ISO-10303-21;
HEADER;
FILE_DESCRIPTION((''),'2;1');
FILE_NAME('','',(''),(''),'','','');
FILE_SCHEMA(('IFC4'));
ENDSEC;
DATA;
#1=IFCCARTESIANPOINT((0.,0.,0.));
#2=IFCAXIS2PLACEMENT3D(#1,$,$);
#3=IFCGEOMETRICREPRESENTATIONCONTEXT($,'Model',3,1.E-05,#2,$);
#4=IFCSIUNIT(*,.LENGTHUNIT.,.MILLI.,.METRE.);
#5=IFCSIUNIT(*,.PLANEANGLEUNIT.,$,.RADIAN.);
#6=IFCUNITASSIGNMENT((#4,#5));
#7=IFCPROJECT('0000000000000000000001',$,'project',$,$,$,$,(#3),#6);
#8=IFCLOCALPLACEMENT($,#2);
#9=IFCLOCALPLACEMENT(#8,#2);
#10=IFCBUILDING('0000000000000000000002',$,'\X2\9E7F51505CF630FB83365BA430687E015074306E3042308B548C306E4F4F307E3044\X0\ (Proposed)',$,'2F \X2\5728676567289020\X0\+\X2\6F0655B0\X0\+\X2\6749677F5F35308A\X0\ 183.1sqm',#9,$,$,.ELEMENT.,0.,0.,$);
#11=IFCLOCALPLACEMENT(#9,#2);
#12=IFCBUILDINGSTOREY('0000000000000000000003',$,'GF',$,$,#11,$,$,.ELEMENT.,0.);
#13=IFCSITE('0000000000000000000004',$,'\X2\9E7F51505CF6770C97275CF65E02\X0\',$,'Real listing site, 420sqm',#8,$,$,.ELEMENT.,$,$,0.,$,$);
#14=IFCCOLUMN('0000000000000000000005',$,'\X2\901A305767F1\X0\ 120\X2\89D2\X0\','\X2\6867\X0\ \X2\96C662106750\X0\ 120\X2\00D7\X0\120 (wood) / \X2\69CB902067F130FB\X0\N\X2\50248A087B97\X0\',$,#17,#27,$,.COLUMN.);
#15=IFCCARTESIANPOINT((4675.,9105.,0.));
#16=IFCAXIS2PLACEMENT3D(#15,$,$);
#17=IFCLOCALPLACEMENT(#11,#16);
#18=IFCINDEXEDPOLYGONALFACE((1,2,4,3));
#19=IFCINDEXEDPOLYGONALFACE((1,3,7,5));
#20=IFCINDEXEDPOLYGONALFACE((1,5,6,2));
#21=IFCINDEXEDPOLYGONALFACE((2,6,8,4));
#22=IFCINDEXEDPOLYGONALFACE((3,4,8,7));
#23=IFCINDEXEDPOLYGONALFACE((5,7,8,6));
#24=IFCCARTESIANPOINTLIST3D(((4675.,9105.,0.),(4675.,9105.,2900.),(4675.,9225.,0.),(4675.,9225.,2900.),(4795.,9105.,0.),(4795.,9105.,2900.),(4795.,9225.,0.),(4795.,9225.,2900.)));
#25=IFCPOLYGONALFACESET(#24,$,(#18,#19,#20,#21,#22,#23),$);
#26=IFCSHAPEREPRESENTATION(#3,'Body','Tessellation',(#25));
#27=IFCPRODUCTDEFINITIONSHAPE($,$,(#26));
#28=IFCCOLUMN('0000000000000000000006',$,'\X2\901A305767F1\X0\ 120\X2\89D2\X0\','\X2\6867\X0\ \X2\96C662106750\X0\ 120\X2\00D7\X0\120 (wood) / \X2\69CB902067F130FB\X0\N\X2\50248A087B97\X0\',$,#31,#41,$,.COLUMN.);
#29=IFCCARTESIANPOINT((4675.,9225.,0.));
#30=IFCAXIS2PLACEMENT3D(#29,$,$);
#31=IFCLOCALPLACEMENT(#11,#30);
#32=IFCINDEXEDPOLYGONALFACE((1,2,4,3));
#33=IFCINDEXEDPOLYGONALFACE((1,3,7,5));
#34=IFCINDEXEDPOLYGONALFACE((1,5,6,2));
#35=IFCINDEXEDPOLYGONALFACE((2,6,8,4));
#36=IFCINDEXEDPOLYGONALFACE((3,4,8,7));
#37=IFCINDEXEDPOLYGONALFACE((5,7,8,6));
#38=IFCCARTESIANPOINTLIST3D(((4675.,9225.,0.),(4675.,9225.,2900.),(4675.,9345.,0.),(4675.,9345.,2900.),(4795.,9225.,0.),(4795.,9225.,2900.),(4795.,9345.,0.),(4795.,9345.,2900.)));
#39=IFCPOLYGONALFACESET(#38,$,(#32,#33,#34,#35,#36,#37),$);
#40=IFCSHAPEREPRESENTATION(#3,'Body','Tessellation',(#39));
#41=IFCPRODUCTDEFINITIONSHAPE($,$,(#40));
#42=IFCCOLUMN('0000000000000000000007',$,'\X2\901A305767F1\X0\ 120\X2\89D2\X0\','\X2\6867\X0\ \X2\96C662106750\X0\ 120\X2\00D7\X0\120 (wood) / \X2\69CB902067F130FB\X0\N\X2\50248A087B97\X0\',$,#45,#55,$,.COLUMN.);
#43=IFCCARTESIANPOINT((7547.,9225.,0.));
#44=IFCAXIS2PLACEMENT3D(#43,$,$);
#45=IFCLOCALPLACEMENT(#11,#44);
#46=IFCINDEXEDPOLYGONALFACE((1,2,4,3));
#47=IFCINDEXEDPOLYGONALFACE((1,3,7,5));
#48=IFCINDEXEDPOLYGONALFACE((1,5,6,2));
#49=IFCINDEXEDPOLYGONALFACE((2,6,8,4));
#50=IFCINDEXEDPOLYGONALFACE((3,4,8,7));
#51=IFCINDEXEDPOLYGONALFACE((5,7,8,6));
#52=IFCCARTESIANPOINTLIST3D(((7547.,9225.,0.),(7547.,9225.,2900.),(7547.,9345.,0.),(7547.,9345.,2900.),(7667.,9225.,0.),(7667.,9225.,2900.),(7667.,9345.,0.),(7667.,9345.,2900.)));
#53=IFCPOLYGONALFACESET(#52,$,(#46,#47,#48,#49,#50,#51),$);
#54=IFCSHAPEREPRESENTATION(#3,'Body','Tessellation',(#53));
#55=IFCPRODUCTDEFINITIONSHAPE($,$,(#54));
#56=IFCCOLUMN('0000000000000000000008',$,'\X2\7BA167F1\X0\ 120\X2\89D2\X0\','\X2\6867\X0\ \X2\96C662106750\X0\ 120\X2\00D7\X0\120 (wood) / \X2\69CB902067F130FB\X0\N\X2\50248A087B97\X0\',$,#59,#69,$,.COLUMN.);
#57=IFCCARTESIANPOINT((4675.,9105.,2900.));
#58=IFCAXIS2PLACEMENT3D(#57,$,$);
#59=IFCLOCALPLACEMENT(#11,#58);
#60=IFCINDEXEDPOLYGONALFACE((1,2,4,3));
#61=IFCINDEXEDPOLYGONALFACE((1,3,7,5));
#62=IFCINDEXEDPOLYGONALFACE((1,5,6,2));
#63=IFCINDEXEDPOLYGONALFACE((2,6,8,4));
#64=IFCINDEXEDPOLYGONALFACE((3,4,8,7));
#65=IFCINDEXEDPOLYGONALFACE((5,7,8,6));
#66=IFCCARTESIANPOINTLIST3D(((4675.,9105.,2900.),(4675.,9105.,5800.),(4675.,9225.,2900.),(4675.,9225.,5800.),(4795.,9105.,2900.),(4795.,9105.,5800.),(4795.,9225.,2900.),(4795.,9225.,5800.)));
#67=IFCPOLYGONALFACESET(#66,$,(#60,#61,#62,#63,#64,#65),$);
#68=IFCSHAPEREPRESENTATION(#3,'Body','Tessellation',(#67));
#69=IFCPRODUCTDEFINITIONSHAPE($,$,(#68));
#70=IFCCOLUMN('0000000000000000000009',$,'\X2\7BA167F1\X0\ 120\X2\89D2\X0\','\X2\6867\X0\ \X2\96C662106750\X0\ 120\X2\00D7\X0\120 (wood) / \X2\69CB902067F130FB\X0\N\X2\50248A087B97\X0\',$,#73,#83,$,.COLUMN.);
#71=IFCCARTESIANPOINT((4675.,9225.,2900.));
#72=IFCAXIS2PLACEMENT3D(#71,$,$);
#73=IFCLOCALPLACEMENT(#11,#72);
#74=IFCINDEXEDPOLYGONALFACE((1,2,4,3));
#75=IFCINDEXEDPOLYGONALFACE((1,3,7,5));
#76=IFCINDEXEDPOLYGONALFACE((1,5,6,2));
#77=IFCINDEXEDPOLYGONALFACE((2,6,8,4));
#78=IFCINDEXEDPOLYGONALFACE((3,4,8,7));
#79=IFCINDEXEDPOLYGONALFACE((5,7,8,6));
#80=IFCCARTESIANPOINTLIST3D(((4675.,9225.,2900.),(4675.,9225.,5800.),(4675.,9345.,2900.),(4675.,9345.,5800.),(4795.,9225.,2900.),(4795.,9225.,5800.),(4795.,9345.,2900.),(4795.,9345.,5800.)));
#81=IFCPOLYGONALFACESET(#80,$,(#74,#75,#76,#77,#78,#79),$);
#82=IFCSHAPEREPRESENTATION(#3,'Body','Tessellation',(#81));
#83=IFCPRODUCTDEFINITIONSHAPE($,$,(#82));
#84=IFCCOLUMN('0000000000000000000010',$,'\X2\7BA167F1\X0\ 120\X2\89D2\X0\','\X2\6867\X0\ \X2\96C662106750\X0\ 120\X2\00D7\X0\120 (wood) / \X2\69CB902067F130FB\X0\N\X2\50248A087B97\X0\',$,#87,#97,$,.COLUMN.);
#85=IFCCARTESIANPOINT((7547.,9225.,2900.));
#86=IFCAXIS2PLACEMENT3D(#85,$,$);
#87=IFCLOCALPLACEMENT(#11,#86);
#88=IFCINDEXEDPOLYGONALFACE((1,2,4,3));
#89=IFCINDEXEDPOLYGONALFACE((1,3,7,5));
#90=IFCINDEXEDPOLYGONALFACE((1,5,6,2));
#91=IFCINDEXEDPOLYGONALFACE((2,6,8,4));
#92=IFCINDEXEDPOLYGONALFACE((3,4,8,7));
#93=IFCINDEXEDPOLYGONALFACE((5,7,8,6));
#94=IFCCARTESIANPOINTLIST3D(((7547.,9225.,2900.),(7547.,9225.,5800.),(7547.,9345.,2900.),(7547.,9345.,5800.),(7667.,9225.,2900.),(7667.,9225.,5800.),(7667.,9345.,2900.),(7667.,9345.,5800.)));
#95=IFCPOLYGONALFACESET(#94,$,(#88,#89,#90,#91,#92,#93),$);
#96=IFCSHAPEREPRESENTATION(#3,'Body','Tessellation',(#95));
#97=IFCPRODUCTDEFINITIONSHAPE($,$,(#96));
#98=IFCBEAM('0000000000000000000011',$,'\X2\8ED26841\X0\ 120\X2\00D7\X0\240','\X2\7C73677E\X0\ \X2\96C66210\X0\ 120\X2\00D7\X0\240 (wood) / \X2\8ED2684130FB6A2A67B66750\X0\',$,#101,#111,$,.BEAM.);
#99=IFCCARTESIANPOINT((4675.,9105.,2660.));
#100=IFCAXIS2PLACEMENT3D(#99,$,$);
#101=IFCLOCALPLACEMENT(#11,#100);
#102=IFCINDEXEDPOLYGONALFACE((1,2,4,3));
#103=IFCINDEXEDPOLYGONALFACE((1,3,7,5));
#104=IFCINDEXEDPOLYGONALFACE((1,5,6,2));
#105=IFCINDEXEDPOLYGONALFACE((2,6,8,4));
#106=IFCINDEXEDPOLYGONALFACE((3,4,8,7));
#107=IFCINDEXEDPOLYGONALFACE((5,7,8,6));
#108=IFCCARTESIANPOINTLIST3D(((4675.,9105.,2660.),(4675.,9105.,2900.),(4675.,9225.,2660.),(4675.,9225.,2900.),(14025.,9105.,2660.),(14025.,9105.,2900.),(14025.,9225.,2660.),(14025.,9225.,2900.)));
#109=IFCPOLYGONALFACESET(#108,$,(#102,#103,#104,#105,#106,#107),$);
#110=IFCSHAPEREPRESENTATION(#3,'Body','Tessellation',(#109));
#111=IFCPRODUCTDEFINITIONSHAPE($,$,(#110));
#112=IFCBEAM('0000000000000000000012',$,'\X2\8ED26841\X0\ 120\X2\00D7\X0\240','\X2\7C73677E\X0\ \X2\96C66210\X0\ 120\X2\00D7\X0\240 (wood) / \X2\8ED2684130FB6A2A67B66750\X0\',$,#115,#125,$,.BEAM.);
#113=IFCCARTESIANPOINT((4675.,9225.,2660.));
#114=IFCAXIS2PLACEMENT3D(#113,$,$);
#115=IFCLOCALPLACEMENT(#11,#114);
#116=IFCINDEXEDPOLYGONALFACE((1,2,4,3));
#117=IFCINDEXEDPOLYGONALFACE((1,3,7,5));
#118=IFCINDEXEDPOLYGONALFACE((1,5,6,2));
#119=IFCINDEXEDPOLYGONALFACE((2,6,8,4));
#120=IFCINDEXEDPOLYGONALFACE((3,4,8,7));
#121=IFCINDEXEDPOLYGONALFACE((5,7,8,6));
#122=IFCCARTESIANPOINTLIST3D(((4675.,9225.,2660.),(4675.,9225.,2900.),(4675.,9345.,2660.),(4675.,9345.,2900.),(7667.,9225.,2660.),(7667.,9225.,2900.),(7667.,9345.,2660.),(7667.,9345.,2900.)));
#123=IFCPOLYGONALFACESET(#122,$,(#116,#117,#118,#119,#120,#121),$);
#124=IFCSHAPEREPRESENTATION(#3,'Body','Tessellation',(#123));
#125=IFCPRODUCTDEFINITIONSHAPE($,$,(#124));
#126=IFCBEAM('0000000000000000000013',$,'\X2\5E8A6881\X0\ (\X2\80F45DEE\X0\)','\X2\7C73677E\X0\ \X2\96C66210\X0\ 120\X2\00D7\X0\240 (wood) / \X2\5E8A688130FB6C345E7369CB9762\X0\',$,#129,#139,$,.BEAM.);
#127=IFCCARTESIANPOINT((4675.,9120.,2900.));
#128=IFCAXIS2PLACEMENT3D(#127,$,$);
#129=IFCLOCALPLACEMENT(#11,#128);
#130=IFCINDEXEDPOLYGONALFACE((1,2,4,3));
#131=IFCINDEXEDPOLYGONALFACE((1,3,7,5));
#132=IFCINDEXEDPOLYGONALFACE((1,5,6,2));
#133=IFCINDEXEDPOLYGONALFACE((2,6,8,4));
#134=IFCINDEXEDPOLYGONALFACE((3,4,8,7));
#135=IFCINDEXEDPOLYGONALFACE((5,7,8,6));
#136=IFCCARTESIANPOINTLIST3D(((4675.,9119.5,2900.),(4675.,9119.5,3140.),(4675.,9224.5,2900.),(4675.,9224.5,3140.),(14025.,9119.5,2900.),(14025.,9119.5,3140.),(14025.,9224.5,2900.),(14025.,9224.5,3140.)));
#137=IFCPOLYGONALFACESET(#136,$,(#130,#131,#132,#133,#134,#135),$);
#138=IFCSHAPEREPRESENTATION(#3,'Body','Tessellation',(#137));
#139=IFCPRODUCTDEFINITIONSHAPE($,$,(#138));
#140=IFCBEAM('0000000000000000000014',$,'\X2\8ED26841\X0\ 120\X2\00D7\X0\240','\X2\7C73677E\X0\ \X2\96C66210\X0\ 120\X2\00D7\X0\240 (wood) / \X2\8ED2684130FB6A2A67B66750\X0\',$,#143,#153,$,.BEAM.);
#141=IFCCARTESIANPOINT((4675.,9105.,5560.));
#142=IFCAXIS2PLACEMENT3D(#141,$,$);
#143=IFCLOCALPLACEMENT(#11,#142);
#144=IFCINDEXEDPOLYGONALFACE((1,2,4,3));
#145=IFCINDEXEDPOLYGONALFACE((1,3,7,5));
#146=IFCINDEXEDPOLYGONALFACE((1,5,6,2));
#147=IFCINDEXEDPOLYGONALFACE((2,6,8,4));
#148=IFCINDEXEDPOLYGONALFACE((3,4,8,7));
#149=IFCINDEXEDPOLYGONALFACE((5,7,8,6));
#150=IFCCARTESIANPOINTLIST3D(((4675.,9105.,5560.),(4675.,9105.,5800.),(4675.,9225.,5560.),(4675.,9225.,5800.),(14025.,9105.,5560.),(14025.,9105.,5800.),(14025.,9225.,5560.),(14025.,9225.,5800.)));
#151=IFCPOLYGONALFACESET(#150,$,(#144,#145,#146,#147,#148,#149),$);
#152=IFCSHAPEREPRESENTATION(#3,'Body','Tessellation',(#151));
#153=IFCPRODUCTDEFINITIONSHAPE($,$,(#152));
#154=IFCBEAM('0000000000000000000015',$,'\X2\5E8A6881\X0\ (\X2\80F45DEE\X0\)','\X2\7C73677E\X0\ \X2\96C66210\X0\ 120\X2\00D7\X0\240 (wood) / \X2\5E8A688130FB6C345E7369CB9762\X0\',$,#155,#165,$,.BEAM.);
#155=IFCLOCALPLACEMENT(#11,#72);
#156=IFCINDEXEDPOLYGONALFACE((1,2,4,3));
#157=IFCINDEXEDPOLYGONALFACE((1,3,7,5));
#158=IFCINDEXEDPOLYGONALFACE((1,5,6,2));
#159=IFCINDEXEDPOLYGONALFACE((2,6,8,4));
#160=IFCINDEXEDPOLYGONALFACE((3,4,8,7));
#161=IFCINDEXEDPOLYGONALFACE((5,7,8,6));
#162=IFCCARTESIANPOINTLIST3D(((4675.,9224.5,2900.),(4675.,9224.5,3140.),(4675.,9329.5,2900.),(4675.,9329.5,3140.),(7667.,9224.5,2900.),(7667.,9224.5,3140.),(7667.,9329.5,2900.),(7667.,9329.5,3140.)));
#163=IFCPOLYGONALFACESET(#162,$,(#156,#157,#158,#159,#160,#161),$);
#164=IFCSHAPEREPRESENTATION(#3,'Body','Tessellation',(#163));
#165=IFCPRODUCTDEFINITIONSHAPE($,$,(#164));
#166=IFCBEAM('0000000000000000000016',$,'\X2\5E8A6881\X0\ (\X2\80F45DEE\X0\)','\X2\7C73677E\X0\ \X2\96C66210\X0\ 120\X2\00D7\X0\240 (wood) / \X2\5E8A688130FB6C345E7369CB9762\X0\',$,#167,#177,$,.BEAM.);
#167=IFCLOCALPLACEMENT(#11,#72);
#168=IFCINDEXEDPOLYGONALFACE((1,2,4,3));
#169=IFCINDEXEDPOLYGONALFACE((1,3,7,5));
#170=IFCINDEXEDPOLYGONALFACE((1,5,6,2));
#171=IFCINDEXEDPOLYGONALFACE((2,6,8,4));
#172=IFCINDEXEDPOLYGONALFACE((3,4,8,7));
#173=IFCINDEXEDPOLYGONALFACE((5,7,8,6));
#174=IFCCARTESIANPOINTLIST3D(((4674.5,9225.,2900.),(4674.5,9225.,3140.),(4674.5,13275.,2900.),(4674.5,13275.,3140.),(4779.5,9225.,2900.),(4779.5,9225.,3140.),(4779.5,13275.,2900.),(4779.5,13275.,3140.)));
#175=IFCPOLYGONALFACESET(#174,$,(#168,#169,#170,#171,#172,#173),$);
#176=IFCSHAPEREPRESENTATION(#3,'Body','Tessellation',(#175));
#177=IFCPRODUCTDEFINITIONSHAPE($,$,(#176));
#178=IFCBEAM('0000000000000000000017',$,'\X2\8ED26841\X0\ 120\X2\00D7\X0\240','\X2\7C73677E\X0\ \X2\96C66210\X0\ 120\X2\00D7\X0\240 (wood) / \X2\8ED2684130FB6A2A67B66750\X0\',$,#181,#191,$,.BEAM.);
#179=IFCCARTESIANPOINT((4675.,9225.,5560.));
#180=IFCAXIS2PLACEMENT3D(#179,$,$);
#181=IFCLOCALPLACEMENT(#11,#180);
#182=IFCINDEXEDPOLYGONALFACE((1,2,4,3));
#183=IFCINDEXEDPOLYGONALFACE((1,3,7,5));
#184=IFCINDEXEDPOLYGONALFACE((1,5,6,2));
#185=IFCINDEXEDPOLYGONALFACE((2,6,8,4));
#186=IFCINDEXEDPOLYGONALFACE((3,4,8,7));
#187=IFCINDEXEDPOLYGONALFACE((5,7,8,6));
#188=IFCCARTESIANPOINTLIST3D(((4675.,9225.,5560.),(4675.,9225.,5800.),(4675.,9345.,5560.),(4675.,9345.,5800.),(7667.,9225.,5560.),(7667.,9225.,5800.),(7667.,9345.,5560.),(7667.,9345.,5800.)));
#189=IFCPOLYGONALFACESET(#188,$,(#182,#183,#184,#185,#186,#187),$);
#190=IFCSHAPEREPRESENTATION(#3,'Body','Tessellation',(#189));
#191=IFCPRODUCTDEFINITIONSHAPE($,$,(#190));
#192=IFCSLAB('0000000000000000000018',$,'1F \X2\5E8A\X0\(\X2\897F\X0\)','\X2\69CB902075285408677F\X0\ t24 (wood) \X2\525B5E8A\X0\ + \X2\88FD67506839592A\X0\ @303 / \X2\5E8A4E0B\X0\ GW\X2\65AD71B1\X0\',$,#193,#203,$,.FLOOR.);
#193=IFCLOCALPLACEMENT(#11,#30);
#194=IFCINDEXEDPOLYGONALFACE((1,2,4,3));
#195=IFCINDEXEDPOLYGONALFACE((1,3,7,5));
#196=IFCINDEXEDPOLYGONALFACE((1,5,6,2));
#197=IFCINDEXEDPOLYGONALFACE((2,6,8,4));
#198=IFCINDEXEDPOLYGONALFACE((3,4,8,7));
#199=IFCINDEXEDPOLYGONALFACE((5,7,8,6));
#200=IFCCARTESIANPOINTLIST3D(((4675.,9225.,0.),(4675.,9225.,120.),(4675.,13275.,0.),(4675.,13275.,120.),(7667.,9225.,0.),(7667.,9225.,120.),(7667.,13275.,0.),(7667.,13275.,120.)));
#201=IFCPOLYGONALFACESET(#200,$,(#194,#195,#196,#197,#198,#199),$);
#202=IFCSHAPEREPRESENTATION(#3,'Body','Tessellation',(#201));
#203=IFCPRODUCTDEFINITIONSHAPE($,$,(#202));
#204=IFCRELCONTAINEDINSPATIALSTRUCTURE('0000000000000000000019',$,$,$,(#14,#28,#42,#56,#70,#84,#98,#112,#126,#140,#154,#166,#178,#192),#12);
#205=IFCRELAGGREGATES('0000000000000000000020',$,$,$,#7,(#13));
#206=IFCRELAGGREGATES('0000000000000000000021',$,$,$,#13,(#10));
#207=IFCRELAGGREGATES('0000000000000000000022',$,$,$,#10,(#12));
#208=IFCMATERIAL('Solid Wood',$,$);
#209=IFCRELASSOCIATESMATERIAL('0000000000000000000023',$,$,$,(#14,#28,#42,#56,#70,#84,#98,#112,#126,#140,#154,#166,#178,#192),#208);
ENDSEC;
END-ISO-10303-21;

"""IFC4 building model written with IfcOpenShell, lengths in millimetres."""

from ifc_helpers import new_model, si_unit, frame, frame_2d, origin, place, context, project, spatial, rectangle, extrude, material, element, save


model = new_model("IFC4")

# Units and contexts
model_context = context("Model", 3, precision=1e-05, world=origin())
ifc_project = project(units=[si_unit("LENGTHUNIT", "METRE", prefix="MILLI"), si_unit("PLANEANGLEUNIT", "RADIAN")], contexts=[model_context])

# Site, building, storey
site_placement = place(None, origin())
site = spatial("IfcSite", under=ifc_project, at=site_placement, Name="鹿児島県霧島市", ObjectType="Real listing site, 420sqm", CompositionType="ELEMENT", RefElevation=0.0)
building_placement = place(site_placement, origin())
building = spatial("IfcBuilding", under=site, at=building_placement, Name="鹿児島・茶室と縁側のある和の住まい (Proposed)", ObjectType="2F 在来木造+漆喰+杉板張り 183.1sqm", CompositionType="ELEMENT", ElevationOfRefHeight=0.0, ElevationOfTerrain=0.0)
storey_placement = place(building_placement, origin())
storey = spatial("IfcBuildingStorey", under=building, at=storey_placement, Name="GF", CompositionType="ELEMENT", Elevation=0.0)

# Columns
ifc_material_1 = material(Name="Solid Wood")
column_1_placement = place(storey_placement, frame((4675.0, 9105.0, 0.0)))
element("IfcColumn", 1, at=column_1_placement, inside=storey, material=ifc_material_1, Name="通し柱 120角", Description="桧 集成材 120×120 (wood) / 構造柱・N値計算", PredefinedType="COLUMN", context=model_context, shape_type="SweptSolid", body=[
    extrude(rectangle(XDim=120.0, YDim=120.0, at=frame_2d((60.0, 60.0))), frame((4675.0, 9105.0, 0.0)), (0.0, 0.0, 1.0), 2900.0),
])
column_2_placement = place(storey_placement, frame((4675.0, 9225.0, 0.0)))
element("IfcColumn", 2, at=column_2_placement, inside=storey, material=ifc_material_1, Name="通し柱 120角", Description="桧 集成材 120×120 (wood) / 構造柱・N値計算", PredefinedType="COLUMN", context=model_context, shape_type="SweptSolid", body=[
    extrude(rectangle(XDim=120.0, YDim=120.0, at=frame_2d((60.0, 60.0))), frame((4675.0, 9225.0, 0.0)), (0.0, 0.0, 1.0), 2900.0),
])
column_3_placement = place(storey_placement, frame((7547.0, 9225.0, 0.0)))
element("IfcColumn", 3, at=column_3_placement, inside=storey, material=ifc_material_1, Name="通し柱 120角", Description="桧 集成材 120×120 (wood) / 構造柱・N値計算", PredefinedType="COLUMN", context=model_context, shape_type="SweptSolid", body=[
    extrude(rectangle(XDim=120.0, YDim=120.0, at=frame_2d((60.0, 60.0))), frame((7547.0, 9225.0, 0.0)), (0.0, 0.0, 1.0), 2900.0),
])
column_4_placement = place(storey_placement, frame((4675.0, 9105.0, 2900.0)))
element("IfcColumn", 4, at=column_4_placement, inside=storey, material=ifc_material_1, Name="管柱 120角", Description="桧 集成材 120×120 (wood) / 構造柱・N値計算", PredefinedType="COLUMN", context=model_context, shape_type="SweptSolid", body=[
    extrude(rectangle(XDim=120.0, YDim=120.0, at=frame_2d((60.0, 60.0))), frame((4675.0, 9105.0, 2900.0)), (0.0, 0.0, 1.0), 2900.0),
])
column_5_placement = place(storey_placement, frame((4675.0, 9225.0, 2900.0)))
element("IfcColumn", 5, at=column_5_placement, inside=storey, material=ifc_material_1, Name="管柱 120角", Description="桧 集成材 120×120 (wood) / 構造柱・N値計算", PredefinedType="COLUMN", context=model_context, shape_type="SweptSolid", body=[
    extrude(rectangle(XDim=120.0, YDim=120.0, at=frame_2d((60.0, 60.0))), frame((4675.0, 9225.0, 2900.0)), (0.0, 0.0, 1.0), 2900.0),
])
column_6_placement = place(storey_placement, frame((7547.0, 9225.0, 2900.0)))
element("IfcColumn", 6, at=column_6_placement, inside=storey, material=ifc_material_1, Name="管柱 120角", Description="桧 集成材 120×120 (wood) / 構造柱・N値計算", PredefinedType="COLUMN", context=model_context, shape_type="SweptSolid", body=[
    extrude(rectangle(XDim=120.0, YDim=120.0, at=frame_2d((60.0, 60.0))), frame((7547.0, 9225.0, 2900.0)), (0.0, 0.0, 1.0), 2900.0),
])

# Beams
beam_1_placement = place(storey_placement, frame((4675.0, 9105.0, 2660.0)))
element("IfcBeam", 7, at=beam_1_placement, inside=storey, material=ifc_material_1, Name="軒桁 120×240", Description="米松 集成 120×240 (wood) / 軒桁・横架材", PredefinedType="BEAM", context=model_context, shape_type="SweptSolid", body=[
    extrude(rectangle(XDim=9350.0, YDim=120.0, at=frame_2d((4675.0, 60.0))), frame((4675.0, 9105.0, 2660.0)), (0.0, 0.0, 1.0), 240.0),
])
beam_2_placement = place(storey_placement, frame((4675.0, 9225.0, 2660.0)))
element("IfcBeam", 8, at=beam_2_placement, inside=storey, material=ifc_material_1, Name="軒桁 120×240", Description="米松 集成 120×240 (wood) / 軒桁・横架材", PredefinedType="BEAM", context=model_context, shape_type="SweptSolid", body=[
    extrude(rectangle(XDim=2992.0, YDim=120.0, at=frame_2d((1496.0, 60.0))), frame((4675.0, 9225.0, 2660.0)), (0.0, 0.0, 1.0), 240.0),
])
beam_3_placement = place(storey_placement, frame((4675.0, 9120.0, 2900.0)))
element("IfcBeam", 9, at=beam_3_placement, inside=storey, material=ifc_material_1, Name="床梁 (胴差)", Description="米松 集成 120×240 (wood) / 床梁・水平構面", PredefinedType="BEAM", context=model_context, shape_type="SweptSolid", body=[
    extrude(rectangle(XDim=9350.0, YDim=105.0, at=frame_2d((4675.0, 52.0))), frame((4675.0, 9120.0, 2900.0)), (0.0, 0.0, 1.0), 240.0),
])
beam_4_placement = place(storey_placement, frame((4675.0, 9105.0, 5560.0)))
element("IfcBeam", 10, at=beam_4_placement, inside=storey, material=ifc_material_1, Name="軒桁 120×240", Description="米松 集成 120×240 (wood) / 軒桁・横架材", PredefinedType="BEAM", context=model_context, shape_type="SweptSolid", body=[
    extrude(rectangle(XDim=9350.0, YDim=120.0, at=frame_2d((4675.0, 60.0))), frame((4675.0, 9105.0, 5560.0)), (0.0, 0.0, 1.0), 240.0),
])
beam_5_placement = place(storey_placement, frame((4675.0, 9225.0, 2900.0)))
element("IfcBeam", 11, at=beam_5_placement, inside=storey, material=ifc_material_1, Name="床梁 (胴差)", Description="米松 集成 120×240 (wood) / 床梁・水平構面", PredefinedType="BEAM", context=model_context, shape_type="SweptSolid", body=[
    extrude(rectangle(XDim=2992.0, YDim=105.0, at=frame_2d((1496.0, 52.0))), frame((4675.0, 9225.0, 2900.0)), (0.0, 0.0, 1.0), 240.0),
])
beam_6_placement = place(storey_placement, frame((4675.0, 9225.0, 2900.0)))
element("IfcBeam", 12, at=beam_6_placement, inside=storey, material=ifc_material_1, Name="床梁 (胴差)", Description="米松 集成 120×240 (wood) / 床梁・水平構面", PredefinedType="BEAM", context=model_context, shape_type="SweptSolid", body=[
    extrude(rectangle(XDim=105.0, YDim=4050.0, at=frame_2d((52.0, 2025.0))), frame((4675.0, 9225.0, 2900.0)), (0.0, 0.0, 1.0), 240.0),
])
beam_7_placement = place(storey_placement, frame((4675.0, 9225.0, 5560.0)))
element("IfcBeam", 13, at=beam_7_placement, inside=storey, material=ifc_material_1, Name="軒桁 120×240", Description="米松 集成 120×240 (wood) / 軒桁・横架材", PredefinedType="BEAM", context=model_context, shape_type="SweptSolid", body=[
    extrude(rectangle(XDim=2992.0, YDim=120.0, at=frame_2d((1496.0, 60.0))), frame((4675.0, 9225.0, 5560.0)), (0.0, 0.0, 1.0), 240.0),
])

# Slab
slab_1_placement = place(storey_placement, frame((4675.0, 9225.0, 0.0)))
element("IfcSlab", 14, at=slab_1_placement, inside=storey, material=ifc_material_1, Name="1F 床(西)", Description="構造用合板 t24 (wood) 剛床 + 製材根太 @303 / 床下 GW断熱", PredefinedType="FLOOR", context=model_context, shape_type="SweptSolid", body=[
    extrude(rectangle(XDim=2992.0, YDim=4050.0, at=frame_2d((1496.0, 2025.0))), frame((4675.0, 9225.0, 0.0)), (0.0, 0.0, 1.0), 120.0),
])

save(model, "model.ifc")
